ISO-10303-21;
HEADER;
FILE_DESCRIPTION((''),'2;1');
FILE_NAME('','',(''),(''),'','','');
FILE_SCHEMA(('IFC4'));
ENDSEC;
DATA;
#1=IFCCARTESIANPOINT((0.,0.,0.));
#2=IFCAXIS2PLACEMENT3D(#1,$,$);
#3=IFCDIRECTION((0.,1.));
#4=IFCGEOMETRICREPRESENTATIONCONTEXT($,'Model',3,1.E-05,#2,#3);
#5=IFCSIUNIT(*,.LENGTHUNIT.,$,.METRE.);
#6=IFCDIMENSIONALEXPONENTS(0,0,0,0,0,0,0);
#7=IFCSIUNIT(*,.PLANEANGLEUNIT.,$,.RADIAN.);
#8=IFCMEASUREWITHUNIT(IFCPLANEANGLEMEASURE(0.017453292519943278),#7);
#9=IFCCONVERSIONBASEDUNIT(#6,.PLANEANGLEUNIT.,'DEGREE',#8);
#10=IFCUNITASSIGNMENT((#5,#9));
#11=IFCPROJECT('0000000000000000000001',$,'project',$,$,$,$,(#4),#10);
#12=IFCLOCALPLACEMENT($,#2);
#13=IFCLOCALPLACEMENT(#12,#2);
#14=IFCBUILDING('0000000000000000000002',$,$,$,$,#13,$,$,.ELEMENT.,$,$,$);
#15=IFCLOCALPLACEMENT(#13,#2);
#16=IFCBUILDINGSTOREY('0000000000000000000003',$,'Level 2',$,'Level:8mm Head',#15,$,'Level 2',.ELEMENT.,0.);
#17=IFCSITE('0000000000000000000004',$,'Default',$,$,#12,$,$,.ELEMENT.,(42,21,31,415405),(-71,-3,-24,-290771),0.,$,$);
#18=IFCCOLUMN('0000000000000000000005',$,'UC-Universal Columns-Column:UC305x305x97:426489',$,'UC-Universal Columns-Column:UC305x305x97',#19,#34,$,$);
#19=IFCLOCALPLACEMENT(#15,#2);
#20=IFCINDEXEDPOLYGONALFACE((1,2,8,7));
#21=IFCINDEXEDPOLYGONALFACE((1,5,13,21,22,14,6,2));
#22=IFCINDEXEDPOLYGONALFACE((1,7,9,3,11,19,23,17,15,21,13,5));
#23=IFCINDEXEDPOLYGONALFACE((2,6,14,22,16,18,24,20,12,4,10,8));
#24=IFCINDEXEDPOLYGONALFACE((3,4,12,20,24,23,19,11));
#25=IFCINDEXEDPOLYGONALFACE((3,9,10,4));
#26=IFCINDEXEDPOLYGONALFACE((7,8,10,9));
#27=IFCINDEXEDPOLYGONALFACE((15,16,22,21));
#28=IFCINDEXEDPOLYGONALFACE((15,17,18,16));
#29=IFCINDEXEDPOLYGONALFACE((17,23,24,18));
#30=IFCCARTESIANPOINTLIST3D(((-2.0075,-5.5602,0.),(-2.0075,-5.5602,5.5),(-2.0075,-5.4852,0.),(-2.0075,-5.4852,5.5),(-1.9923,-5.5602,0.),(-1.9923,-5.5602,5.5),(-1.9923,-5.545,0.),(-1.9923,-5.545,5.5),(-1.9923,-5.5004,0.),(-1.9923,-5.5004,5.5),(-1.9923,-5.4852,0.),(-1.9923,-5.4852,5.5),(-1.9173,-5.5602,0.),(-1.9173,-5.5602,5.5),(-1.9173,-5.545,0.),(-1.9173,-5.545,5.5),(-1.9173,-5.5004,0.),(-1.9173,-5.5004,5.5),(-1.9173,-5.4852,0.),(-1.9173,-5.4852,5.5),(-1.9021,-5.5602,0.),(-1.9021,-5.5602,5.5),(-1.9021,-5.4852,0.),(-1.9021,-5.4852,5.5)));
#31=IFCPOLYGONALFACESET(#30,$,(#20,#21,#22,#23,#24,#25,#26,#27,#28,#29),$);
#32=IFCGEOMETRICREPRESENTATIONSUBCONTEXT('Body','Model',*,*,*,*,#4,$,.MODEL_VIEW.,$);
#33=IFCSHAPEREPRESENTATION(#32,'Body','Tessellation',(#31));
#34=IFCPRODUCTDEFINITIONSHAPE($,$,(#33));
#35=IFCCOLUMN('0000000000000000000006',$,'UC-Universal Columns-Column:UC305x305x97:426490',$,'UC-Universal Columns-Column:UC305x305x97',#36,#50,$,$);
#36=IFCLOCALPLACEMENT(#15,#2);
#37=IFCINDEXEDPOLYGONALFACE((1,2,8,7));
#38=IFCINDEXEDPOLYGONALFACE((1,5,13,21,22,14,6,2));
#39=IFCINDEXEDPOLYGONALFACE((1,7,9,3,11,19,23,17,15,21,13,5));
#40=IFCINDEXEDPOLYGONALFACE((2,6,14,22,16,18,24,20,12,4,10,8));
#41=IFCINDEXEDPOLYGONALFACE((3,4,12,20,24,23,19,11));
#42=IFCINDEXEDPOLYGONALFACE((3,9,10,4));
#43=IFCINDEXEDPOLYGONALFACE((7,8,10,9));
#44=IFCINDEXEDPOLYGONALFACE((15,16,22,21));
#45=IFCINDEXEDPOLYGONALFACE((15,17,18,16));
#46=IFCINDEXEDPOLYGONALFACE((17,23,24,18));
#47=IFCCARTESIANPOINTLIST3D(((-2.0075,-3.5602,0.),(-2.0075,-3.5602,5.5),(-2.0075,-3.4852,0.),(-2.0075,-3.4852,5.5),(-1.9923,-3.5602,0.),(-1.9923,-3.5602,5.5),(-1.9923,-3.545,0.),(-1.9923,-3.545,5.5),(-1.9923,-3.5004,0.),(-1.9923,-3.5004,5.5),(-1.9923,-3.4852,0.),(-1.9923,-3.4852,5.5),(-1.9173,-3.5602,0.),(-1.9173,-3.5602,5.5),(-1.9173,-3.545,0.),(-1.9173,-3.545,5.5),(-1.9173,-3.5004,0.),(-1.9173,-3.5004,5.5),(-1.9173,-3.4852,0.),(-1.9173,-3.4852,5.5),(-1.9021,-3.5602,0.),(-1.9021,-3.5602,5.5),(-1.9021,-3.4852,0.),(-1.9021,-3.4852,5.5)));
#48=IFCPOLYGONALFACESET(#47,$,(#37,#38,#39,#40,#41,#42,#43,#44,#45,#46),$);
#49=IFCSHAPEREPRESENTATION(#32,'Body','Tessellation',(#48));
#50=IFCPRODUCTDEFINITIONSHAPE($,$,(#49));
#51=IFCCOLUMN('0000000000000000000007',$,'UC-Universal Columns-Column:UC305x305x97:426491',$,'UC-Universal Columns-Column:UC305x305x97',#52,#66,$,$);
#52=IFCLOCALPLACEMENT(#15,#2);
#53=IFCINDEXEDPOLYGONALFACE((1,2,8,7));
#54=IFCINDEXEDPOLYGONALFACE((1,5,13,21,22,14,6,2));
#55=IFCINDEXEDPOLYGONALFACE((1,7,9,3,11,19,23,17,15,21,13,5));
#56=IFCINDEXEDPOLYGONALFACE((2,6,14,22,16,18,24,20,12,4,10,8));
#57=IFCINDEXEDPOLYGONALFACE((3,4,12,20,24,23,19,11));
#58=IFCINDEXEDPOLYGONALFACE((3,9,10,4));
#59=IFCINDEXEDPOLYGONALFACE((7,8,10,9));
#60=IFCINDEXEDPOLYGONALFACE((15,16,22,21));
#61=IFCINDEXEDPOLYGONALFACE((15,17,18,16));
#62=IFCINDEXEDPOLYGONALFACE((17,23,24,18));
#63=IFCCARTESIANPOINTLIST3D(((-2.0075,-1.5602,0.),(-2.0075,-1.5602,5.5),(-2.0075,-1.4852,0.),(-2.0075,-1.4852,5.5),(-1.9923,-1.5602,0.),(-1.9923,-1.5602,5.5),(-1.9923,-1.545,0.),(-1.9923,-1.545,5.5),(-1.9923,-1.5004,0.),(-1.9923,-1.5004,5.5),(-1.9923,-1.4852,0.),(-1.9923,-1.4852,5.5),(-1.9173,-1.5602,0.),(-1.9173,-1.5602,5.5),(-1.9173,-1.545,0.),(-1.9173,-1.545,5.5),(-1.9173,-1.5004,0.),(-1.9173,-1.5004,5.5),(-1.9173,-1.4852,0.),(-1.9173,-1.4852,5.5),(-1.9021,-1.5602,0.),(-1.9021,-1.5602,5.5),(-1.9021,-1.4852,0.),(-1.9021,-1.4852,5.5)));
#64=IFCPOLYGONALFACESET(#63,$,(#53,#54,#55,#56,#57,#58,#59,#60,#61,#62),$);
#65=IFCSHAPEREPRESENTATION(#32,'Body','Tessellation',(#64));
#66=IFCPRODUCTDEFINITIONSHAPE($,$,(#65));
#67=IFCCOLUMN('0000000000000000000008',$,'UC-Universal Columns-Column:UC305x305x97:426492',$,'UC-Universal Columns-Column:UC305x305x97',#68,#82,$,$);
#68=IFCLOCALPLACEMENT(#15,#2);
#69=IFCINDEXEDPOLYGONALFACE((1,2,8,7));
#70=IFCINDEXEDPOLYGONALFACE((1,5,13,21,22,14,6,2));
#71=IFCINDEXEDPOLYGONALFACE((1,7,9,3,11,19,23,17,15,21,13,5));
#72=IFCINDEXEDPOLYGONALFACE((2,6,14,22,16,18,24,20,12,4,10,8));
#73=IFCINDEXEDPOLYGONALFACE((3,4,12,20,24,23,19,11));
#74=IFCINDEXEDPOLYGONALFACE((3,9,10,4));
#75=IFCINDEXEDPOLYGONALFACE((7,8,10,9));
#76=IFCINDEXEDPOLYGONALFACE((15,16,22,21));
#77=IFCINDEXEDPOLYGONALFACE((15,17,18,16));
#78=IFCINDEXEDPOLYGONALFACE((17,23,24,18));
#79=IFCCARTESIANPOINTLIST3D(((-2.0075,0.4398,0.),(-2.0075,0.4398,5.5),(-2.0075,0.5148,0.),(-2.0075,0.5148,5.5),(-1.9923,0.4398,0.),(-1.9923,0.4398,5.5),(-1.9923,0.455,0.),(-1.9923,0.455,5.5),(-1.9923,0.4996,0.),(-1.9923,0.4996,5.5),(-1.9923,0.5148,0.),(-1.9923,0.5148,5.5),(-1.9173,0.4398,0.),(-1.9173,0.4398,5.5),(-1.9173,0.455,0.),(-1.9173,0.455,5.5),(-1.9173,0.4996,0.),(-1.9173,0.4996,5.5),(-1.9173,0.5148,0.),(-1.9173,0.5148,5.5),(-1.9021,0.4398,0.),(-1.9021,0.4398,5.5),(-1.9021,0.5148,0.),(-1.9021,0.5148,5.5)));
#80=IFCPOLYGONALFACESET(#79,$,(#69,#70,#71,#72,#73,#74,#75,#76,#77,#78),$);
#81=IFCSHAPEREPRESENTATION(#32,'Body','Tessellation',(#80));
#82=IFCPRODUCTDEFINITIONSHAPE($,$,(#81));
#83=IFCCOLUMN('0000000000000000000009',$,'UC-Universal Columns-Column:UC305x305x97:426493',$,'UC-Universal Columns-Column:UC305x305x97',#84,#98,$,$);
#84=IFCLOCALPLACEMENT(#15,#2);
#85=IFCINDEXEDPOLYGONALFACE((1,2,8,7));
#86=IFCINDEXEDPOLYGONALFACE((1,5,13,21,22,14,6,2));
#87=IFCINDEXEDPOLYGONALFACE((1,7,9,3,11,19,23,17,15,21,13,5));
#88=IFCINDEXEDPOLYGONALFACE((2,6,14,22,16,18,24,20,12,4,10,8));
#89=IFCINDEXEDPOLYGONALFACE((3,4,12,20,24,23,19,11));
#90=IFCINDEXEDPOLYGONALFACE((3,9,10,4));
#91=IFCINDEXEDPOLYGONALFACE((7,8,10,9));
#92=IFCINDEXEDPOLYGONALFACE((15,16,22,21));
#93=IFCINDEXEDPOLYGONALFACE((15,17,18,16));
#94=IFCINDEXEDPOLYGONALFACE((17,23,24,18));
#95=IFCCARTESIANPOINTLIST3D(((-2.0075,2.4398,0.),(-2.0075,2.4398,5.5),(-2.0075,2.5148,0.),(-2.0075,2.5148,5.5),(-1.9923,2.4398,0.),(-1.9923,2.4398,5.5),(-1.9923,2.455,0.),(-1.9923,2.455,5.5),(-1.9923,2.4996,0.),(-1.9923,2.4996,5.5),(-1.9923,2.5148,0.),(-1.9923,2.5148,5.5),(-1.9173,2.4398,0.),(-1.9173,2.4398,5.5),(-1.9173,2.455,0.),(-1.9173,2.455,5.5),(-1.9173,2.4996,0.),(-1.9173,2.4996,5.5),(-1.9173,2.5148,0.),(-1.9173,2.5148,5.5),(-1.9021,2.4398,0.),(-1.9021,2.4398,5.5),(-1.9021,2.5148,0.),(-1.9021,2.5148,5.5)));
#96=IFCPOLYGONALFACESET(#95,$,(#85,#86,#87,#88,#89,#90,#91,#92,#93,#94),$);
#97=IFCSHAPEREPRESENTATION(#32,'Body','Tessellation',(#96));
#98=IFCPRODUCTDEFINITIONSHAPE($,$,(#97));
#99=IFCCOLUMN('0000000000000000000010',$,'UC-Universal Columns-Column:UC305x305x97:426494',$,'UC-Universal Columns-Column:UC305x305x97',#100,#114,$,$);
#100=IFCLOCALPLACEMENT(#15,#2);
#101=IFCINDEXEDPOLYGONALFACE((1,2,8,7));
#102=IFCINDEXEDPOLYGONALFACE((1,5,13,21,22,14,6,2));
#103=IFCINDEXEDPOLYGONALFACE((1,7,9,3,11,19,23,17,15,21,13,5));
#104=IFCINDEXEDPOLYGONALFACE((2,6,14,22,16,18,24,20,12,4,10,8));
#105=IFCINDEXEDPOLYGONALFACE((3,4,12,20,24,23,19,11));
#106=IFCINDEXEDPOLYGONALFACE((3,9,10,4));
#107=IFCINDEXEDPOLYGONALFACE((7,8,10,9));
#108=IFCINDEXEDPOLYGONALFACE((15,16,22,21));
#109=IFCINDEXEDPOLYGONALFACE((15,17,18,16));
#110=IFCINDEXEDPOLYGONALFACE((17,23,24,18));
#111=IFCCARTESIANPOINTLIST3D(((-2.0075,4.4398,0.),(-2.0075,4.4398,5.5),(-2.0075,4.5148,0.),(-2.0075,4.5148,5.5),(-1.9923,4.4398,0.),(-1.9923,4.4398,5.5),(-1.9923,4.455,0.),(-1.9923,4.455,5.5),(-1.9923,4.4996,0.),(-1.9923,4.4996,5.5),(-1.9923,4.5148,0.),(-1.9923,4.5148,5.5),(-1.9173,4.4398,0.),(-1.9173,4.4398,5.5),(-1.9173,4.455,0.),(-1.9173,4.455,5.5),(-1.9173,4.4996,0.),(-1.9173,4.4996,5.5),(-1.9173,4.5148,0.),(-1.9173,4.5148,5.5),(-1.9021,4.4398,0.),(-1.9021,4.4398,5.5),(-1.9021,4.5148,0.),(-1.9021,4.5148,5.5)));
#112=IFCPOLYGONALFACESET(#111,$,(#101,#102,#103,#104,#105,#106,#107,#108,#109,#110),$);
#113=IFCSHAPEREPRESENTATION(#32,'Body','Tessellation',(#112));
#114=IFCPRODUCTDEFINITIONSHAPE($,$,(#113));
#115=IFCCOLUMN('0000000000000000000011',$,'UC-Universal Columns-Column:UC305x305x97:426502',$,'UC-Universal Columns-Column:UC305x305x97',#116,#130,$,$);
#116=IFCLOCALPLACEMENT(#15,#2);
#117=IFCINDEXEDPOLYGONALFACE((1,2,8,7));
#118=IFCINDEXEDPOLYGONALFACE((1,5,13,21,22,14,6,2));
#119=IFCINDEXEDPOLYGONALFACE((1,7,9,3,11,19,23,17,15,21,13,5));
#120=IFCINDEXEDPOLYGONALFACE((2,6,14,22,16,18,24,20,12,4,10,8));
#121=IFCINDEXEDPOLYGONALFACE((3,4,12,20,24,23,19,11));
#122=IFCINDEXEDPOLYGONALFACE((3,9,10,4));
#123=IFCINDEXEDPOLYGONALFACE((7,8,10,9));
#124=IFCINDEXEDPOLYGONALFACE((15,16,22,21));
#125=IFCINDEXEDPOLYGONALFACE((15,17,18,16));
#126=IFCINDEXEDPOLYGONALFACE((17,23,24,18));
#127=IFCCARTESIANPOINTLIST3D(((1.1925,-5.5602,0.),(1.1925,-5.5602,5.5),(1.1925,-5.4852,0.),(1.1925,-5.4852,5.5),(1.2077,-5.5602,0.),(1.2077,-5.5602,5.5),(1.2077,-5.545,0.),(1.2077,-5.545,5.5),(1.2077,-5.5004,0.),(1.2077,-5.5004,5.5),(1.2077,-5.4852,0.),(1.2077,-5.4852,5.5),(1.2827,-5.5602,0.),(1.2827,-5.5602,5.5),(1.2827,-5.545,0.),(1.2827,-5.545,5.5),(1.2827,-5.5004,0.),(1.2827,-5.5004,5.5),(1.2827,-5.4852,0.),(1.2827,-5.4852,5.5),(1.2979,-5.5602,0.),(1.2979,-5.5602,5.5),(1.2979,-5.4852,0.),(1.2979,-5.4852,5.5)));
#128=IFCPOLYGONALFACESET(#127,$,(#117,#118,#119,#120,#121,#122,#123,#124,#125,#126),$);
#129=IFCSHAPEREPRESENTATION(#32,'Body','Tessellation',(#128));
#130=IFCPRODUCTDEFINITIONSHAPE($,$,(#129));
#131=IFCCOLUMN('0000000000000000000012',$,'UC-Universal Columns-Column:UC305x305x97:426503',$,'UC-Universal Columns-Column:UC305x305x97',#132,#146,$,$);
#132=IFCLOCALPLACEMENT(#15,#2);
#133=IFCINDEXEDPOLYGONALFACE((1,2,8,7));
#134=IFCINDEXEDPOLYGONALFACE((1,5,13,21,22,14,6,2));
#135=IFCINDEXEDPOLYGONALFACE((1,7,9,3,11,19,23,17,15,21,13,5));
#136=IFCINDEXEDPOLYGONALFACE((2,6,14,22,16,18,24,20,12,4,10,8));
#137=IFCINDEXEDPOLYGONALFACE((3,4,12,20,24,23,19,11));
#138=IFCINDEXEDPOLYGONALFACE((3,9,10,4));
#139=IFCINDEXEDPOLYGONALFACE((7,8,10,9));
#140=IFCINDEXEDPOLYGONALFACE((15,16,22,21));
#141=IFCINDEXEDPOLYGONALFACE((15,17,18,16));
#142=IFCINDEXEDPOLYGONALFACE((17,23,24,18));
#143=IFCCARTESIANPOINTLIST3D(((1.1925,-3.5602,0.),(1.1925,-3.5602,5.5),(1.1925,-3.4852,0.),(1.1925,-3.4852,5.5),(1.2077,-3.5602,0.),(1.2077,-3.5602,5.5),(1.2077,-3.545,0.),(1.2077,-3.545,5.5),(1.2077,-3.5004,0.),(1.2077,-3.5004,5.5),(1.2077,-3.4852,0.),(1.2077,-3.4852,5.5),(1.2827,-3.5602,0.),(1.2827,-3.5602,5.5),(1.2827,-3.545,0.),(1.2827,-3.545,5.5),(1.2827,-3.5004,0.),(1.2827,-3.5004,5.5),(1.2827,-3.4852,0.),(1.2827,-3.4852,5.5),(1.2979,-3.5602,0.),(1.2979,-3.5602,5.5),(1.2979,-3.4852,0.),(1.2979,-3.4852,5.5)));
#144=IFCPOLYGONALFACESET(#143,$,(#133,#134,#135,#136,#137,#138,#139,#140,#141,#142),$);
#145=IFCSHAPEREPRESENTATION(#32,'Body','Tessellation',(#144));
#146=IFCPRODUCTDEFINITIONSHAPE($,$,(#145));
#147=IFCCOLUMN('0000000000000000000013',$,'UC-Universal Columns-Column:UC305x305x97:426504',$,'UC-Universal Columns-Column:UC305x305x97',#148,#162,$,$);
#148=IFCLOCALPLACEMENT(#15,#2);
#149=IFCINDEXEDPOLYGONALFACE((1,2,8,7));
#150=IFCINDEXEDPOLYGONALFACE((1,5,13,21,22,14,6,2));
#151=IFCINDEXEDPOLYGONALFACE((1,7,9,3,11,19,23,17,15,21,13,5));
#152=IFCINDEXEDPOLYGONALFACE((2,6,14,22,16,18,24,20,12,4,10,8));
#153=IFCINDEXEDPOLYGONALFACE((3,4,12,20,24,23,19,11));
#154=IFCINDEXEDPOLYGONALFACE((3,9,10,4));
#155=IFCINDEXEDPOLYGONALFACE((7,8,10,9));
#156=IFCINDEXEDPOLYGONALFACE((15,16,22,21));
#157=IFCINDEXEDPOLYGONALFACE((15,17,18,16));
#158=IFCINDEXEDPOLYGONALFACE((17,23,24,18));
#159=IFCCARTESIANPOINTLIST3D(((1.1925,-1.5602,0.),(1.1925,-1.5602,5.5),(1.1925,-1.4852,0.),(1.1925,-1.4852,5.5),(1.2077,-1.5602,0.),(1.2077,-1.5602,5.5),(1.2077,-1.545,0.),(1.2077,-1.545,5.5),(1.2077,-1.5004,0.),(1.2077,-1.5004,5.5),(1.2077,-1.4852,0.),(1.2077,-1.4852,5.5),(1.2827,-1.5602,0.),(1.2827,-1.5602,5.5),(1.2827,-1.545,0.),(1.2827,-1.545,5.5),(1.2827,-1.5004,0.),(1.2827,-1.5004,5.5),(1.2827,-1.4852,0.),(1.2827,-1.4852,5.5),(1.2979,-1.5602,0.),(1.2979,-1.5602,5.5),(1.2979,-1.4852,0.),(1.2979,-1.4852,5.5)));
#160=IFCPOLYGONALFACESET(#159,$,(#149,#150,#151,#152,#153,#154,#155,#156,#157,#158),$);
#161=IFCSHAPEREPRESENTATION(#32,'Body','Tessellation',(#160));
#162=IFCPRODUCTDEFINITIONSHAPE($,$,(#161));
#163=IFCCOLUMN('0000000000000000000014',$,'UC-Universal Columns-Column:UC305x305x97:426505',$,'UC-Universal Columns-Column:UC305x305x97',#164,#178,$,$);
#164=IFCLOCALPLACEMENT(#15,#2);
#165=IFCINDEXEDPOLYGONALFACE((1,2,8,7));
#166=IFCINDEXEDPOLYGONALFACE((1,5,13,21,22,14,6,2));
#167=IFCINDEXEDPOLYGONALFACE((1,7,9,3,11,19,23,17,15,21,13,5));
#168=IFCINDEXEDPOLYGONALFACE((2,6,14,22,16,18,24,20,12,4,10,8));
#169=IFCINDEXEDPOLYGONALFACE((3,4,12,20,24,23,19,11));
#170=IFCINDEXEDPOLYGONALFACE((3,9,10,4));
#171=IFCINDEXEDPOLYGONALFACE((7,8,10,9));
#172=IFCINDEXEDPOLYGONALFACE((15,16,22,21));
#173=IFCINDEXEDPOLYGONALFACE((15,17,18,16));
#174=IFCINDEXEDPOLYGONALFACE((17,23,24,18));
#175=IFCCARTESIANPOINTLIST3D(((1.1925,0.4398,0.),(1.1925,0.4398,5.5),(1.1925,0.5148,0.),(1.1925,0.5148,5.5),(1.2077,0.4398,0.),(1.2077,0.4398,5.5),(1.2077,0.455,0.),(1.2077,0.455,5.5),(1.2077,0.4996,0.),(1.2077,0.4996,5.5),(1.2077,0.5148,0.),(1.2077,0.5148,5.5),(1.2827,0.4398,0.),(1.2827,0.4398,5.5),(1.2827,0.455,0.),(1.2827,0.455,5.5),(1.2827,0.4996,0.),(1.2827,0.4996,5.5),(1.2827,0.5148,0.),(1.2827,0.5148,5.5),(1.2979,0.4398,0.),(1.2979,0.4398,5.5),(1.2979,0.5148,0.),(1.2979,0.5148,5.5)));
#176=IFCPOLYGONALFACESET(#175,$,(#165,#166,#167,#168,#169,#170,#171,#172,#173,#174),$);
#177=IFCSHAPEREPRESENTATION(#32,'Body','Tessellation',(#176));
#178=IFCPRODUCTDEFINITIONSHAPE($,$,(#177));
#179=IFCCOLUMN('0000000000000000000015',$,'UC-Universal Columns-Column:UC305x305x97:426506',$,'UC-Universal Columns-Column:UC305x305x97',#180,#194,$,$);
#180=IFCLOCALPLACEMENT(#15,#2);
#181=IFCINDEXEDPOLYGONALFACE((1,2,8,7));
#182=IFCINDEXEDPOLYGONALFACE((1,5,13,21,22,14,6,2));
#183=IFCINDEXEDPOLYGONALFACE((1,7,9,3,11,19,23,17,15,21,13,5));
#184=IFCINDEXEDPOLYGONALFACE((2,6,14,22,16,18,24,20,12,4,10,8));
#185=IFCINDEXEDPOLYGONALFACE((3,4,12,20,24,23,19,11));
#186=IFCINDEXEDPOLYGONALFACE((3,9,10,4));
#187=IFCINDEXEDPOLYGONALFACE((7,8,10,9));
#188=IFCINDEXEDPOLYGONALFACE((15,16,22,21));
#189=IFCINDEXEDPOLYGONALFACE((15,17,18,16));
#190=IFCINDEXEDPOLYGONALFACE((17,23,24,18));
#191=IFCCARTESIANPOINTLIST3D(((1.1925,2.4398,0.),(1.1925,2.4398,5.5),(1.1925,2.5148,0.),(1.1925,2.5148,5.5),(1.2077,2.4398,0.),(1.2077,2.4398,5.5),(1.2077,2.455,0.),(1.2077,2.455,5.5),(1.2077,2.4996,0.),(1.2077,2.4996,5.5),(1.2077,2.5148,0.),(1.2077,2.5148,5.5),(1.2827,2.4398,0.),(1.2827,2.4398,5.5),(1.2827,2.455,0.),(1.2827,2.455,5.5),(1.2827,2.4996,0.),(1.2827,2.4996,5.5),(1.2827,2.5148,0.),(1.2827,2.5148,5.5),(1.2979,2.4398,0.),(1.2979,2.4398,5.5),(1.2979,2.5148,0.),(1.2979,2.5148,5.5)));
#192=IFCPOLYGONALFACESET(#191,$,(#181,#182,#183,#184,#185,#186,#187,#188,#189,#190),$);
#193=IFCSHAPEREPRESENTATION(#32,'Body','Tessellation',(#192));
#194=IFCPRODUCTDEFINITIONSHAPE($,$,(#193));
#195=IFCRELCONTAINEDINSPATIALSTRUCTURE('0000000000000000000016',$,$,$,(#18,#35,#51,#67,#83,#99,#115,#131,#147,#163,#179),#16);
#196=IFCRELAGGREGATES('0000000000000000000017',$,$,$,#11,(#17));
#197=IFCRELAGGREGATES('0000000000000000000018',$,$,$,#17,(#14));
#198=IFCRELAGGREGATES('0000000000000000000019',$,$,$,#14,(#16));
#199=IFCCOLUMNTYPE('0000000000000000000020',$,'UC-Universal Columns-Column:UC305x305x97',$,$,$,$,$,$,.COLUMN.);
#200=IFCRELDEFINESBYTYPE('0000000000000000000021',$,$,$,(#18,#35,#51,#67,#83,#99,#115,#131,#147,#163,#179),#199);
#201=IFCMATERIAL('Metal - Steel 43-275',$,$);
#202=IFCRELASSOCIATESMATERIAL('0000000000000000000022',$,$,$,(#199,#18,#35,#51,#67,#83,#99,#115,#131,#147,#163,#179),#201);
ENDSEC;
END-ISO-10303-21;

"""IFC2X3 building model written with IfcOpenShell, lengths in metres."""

from ifc_helpers import new_model, entity, si_unit, converted_unit, direction, frame, frame_2d, origin, place, context, subcontext, project, spatial, polyline, circle_curve, parameter, trimmed, segment, composite_curve, outline, extrude, source, transform, mapped, material, type_object, type_shapes, element, save


model = new_model("IFC2X3")

# Units and contexts
model_context = context("Model", 3, precision=1e-05, world=origin(), true_north=direction((0.0, 1.0)))
body_context = subcontext(model_context, "Body", "Model", "MODEL_VIEW")
ifc_project = project(units=[si_unit("LENGTHUNIT", "METRE"), converted_unit("PLANEANGLEUNIT", "DEGREE", entity("IfcPlaneAngleMeasure", 0.017453292519943278), si_unit("PLANEANGLEUNIT", "RADIAN"), dimensions=[0, 0, 0, 0, 0, 0, 0])], contexts=[model_context])

# Site, building, storey
site_placement = place(None, origin())
site = spatial("IfcSite", under=ifc_project, at=site_placement, Name="Default", CompositionType="ELEMENT", RefLatitude=(42, 21, 31, 415405), RefLongitude=(-71, -3, -24, -290771), RefElevation=0.0)
building_placement = place(site_placement, origin())
building = spatial("IfcBuilding", under=site, at=building_placement, CompositionType="ELEMENT")
storey_placement = place(building_placement, origin())
storey = spatial("IfcBuildingStorey", under=building, at=storey_placement, Name="Level 2", ObjectType="Level:8mm Head", LongName="Level 2", CompositionType="ELEMENT", Elevation=0.0)

# Columns
ifc_material_1 = material(Name="Metal - Steel 43-275")
column_type_1 = type_object("IfcColumnType", Name="UC-Universal Columns-Column:UC305x305x97", PredefinedType="COLUMN", material=ifc_material_1)
shared_shape_1 = source(origin(), body_context, "Body", "SweptSolid", [
    extrude(outline(composite_curve([segment(polyline([(-0.0375, -0.0375), (0.0375, -0.0375)]), True, "CONTINUOUS"), segment(polyline([(0.0375, -0.0375), (0.0527, -0.0375)]), True, "CONTINUOUS"), segment(trimmed(circle_curve(frame_2d((0.0527, -0.0223), x_axis=(-1.0, 0.0)), 0.0152), [parameter(0.0)], [parameter(90.0)], True, "PARAMETER"), False, "CONTINUOUS"), segment(polyline([(0.0375, -0.0223), (0.0375, 0.0223)]), True, "CONTINUOUS"), segment(trimmed(circle_curve(frame_2d((0.0527, 0.0223), x_axis=(-1.0, 0.0)), 0.0152), [parameter(270.0)], [parameter(0.0)], True, "PARAMETER"), False, "CONTINUOUS"), segment(polyline([(0.0527, 0.0375), (0.0375, 0.0375)]), True, "CONTINUOUS"), segment(polyline([(0.0375, 0.0375), (-0.0375, 0.0375)]), True, "CONTINUOUS"), segment(polyline([(-0.0375, 0.0375), (-0.0527, 0.0375)]), True, "CONTINUOUS"), segment(trimmed(circle_curve(frame_2d((-0.0527, 0.0223), x_axis=(-1.0, 0.0)), 0.0152), [parameter(180.0)], [parameter(270.0)], True, "PARAMETER"), False, "CONTINUOUS"), segment(polyline([(-0.0375, 0.0223), (-0.0375, -0.0223)]), True, "CONTINUOUS"), segment(trimmed(circle_curve(frame_2d((-0.0527, -0.0223), x_axis=(-1.0, 0.0)), 0.0152), [parameter(90.0)], [parameter(180.0)], True, "PARAMETER"), False, "CONTINUOUS"), segment(polyline([(-0.0527, -0.0375), (-0.0375, -0.0375)]), True, "CONTINUOUS")], self_intersect=False)), frame((0.0, 0.0, 0.0), z_axis=(0.0, 0.0, 1.0), x_axis=(-1.0, 0.0, 0.0)), (0.0, 0.0, 1.0), 5.5),
])
type_shapes(column_type_1, [shared_shape_1])
for number, where, z_axis, x_axis, name in (
    (1, (-1.9548, -5.5227, 0.0), (0.0, 0.0, 1.0), (-1.0, 0.0, 0.0), "UC-Universal Columns-Column:UC305x305x97:426489"),
    (2, (-1.9548, -3.5227, 0.0), (0.0, 0.0, 1.0), (-1.0, 0.0, 0.0), "UC-Universal Columns-Column:UC305x305x97:426490"),
    (3, (-1.9548, -1.5227, 0.0), (0.0, 0.0, 1.0), (-1.0, 0.0, 0.0), "UC-Universal Columns-Column:UC305x305x97:426491"),
    (4, (-1.9548, 0.4773, 0.0), (0.0, 0.0, 1.0), (-1.0, 0.0, 0.0), "UC-Universal Columns-Column:UC305x305x97:426492"),
    (5, (-1.9548, 2.4773, 0.0), (0.0, 0.0, 1.0), (-1.0, 0.0, 0.0), "UC-Universal Columns-Column:UC305x305x97:426493"),
    (6, (-1.9548, 4.4773, 0.0), (0.0, 0.0, 1.0), (-1.0, 0.0, 0.0), "UC-Universal Columns-Column:UC305x305x97:426494"),
    (7, (1.2452, -5.5227, 0.0), (0.0, 0.0, 1.0), (-1.0, 0.0, 0.0), "UC-Universal Columns-Column:UC305x305x97:426502"),
    (8, (1.2452, -3.5227, 0.0), (0.0, 0.0, 1.0), (-1.0, 0.0, 0.0), "UC-Universal Columns-Column:UC305x305x97:426503"),
    (9, (1.2452, -1.5227, 0.0), (0.0, 0.0, 1.0), (-1.0, 0.0, 0.0), "UC-Universal Columns-Column:UC305x305x97:426504"),
    (10, (1.2452, 0.4773, 0.0), (0.0, 0.0, 1.0), (-1.0, 0.0, 0.0), "UC-Universal Columns-Column:UC305x305x97:426505"),
    (11, (1.2452, 2.4773, 0.0), (0.0, 0.0, 1.0), (-1.0, 0.0, 0.0), "UC-Universal Columns-Column:UC305x305x97:426506"),
):
    element("IfcColumn", number, at=place(storey_placement, frame(where, z_axis=z_axis, x_axis=x_axis)), inside=storey, type_object=column_type_1, material=ifc_material_1, Name=name, ObjectType="UC-Universal Columns-Column:UC305x305x97", context=body_context, shape_type="MappedRepresentation", body=[
        mapped(shared_shape_1, transform((0.0, 0.0, 0.0), scale=1.0)),
    ])

save(model, "model.ifc")
